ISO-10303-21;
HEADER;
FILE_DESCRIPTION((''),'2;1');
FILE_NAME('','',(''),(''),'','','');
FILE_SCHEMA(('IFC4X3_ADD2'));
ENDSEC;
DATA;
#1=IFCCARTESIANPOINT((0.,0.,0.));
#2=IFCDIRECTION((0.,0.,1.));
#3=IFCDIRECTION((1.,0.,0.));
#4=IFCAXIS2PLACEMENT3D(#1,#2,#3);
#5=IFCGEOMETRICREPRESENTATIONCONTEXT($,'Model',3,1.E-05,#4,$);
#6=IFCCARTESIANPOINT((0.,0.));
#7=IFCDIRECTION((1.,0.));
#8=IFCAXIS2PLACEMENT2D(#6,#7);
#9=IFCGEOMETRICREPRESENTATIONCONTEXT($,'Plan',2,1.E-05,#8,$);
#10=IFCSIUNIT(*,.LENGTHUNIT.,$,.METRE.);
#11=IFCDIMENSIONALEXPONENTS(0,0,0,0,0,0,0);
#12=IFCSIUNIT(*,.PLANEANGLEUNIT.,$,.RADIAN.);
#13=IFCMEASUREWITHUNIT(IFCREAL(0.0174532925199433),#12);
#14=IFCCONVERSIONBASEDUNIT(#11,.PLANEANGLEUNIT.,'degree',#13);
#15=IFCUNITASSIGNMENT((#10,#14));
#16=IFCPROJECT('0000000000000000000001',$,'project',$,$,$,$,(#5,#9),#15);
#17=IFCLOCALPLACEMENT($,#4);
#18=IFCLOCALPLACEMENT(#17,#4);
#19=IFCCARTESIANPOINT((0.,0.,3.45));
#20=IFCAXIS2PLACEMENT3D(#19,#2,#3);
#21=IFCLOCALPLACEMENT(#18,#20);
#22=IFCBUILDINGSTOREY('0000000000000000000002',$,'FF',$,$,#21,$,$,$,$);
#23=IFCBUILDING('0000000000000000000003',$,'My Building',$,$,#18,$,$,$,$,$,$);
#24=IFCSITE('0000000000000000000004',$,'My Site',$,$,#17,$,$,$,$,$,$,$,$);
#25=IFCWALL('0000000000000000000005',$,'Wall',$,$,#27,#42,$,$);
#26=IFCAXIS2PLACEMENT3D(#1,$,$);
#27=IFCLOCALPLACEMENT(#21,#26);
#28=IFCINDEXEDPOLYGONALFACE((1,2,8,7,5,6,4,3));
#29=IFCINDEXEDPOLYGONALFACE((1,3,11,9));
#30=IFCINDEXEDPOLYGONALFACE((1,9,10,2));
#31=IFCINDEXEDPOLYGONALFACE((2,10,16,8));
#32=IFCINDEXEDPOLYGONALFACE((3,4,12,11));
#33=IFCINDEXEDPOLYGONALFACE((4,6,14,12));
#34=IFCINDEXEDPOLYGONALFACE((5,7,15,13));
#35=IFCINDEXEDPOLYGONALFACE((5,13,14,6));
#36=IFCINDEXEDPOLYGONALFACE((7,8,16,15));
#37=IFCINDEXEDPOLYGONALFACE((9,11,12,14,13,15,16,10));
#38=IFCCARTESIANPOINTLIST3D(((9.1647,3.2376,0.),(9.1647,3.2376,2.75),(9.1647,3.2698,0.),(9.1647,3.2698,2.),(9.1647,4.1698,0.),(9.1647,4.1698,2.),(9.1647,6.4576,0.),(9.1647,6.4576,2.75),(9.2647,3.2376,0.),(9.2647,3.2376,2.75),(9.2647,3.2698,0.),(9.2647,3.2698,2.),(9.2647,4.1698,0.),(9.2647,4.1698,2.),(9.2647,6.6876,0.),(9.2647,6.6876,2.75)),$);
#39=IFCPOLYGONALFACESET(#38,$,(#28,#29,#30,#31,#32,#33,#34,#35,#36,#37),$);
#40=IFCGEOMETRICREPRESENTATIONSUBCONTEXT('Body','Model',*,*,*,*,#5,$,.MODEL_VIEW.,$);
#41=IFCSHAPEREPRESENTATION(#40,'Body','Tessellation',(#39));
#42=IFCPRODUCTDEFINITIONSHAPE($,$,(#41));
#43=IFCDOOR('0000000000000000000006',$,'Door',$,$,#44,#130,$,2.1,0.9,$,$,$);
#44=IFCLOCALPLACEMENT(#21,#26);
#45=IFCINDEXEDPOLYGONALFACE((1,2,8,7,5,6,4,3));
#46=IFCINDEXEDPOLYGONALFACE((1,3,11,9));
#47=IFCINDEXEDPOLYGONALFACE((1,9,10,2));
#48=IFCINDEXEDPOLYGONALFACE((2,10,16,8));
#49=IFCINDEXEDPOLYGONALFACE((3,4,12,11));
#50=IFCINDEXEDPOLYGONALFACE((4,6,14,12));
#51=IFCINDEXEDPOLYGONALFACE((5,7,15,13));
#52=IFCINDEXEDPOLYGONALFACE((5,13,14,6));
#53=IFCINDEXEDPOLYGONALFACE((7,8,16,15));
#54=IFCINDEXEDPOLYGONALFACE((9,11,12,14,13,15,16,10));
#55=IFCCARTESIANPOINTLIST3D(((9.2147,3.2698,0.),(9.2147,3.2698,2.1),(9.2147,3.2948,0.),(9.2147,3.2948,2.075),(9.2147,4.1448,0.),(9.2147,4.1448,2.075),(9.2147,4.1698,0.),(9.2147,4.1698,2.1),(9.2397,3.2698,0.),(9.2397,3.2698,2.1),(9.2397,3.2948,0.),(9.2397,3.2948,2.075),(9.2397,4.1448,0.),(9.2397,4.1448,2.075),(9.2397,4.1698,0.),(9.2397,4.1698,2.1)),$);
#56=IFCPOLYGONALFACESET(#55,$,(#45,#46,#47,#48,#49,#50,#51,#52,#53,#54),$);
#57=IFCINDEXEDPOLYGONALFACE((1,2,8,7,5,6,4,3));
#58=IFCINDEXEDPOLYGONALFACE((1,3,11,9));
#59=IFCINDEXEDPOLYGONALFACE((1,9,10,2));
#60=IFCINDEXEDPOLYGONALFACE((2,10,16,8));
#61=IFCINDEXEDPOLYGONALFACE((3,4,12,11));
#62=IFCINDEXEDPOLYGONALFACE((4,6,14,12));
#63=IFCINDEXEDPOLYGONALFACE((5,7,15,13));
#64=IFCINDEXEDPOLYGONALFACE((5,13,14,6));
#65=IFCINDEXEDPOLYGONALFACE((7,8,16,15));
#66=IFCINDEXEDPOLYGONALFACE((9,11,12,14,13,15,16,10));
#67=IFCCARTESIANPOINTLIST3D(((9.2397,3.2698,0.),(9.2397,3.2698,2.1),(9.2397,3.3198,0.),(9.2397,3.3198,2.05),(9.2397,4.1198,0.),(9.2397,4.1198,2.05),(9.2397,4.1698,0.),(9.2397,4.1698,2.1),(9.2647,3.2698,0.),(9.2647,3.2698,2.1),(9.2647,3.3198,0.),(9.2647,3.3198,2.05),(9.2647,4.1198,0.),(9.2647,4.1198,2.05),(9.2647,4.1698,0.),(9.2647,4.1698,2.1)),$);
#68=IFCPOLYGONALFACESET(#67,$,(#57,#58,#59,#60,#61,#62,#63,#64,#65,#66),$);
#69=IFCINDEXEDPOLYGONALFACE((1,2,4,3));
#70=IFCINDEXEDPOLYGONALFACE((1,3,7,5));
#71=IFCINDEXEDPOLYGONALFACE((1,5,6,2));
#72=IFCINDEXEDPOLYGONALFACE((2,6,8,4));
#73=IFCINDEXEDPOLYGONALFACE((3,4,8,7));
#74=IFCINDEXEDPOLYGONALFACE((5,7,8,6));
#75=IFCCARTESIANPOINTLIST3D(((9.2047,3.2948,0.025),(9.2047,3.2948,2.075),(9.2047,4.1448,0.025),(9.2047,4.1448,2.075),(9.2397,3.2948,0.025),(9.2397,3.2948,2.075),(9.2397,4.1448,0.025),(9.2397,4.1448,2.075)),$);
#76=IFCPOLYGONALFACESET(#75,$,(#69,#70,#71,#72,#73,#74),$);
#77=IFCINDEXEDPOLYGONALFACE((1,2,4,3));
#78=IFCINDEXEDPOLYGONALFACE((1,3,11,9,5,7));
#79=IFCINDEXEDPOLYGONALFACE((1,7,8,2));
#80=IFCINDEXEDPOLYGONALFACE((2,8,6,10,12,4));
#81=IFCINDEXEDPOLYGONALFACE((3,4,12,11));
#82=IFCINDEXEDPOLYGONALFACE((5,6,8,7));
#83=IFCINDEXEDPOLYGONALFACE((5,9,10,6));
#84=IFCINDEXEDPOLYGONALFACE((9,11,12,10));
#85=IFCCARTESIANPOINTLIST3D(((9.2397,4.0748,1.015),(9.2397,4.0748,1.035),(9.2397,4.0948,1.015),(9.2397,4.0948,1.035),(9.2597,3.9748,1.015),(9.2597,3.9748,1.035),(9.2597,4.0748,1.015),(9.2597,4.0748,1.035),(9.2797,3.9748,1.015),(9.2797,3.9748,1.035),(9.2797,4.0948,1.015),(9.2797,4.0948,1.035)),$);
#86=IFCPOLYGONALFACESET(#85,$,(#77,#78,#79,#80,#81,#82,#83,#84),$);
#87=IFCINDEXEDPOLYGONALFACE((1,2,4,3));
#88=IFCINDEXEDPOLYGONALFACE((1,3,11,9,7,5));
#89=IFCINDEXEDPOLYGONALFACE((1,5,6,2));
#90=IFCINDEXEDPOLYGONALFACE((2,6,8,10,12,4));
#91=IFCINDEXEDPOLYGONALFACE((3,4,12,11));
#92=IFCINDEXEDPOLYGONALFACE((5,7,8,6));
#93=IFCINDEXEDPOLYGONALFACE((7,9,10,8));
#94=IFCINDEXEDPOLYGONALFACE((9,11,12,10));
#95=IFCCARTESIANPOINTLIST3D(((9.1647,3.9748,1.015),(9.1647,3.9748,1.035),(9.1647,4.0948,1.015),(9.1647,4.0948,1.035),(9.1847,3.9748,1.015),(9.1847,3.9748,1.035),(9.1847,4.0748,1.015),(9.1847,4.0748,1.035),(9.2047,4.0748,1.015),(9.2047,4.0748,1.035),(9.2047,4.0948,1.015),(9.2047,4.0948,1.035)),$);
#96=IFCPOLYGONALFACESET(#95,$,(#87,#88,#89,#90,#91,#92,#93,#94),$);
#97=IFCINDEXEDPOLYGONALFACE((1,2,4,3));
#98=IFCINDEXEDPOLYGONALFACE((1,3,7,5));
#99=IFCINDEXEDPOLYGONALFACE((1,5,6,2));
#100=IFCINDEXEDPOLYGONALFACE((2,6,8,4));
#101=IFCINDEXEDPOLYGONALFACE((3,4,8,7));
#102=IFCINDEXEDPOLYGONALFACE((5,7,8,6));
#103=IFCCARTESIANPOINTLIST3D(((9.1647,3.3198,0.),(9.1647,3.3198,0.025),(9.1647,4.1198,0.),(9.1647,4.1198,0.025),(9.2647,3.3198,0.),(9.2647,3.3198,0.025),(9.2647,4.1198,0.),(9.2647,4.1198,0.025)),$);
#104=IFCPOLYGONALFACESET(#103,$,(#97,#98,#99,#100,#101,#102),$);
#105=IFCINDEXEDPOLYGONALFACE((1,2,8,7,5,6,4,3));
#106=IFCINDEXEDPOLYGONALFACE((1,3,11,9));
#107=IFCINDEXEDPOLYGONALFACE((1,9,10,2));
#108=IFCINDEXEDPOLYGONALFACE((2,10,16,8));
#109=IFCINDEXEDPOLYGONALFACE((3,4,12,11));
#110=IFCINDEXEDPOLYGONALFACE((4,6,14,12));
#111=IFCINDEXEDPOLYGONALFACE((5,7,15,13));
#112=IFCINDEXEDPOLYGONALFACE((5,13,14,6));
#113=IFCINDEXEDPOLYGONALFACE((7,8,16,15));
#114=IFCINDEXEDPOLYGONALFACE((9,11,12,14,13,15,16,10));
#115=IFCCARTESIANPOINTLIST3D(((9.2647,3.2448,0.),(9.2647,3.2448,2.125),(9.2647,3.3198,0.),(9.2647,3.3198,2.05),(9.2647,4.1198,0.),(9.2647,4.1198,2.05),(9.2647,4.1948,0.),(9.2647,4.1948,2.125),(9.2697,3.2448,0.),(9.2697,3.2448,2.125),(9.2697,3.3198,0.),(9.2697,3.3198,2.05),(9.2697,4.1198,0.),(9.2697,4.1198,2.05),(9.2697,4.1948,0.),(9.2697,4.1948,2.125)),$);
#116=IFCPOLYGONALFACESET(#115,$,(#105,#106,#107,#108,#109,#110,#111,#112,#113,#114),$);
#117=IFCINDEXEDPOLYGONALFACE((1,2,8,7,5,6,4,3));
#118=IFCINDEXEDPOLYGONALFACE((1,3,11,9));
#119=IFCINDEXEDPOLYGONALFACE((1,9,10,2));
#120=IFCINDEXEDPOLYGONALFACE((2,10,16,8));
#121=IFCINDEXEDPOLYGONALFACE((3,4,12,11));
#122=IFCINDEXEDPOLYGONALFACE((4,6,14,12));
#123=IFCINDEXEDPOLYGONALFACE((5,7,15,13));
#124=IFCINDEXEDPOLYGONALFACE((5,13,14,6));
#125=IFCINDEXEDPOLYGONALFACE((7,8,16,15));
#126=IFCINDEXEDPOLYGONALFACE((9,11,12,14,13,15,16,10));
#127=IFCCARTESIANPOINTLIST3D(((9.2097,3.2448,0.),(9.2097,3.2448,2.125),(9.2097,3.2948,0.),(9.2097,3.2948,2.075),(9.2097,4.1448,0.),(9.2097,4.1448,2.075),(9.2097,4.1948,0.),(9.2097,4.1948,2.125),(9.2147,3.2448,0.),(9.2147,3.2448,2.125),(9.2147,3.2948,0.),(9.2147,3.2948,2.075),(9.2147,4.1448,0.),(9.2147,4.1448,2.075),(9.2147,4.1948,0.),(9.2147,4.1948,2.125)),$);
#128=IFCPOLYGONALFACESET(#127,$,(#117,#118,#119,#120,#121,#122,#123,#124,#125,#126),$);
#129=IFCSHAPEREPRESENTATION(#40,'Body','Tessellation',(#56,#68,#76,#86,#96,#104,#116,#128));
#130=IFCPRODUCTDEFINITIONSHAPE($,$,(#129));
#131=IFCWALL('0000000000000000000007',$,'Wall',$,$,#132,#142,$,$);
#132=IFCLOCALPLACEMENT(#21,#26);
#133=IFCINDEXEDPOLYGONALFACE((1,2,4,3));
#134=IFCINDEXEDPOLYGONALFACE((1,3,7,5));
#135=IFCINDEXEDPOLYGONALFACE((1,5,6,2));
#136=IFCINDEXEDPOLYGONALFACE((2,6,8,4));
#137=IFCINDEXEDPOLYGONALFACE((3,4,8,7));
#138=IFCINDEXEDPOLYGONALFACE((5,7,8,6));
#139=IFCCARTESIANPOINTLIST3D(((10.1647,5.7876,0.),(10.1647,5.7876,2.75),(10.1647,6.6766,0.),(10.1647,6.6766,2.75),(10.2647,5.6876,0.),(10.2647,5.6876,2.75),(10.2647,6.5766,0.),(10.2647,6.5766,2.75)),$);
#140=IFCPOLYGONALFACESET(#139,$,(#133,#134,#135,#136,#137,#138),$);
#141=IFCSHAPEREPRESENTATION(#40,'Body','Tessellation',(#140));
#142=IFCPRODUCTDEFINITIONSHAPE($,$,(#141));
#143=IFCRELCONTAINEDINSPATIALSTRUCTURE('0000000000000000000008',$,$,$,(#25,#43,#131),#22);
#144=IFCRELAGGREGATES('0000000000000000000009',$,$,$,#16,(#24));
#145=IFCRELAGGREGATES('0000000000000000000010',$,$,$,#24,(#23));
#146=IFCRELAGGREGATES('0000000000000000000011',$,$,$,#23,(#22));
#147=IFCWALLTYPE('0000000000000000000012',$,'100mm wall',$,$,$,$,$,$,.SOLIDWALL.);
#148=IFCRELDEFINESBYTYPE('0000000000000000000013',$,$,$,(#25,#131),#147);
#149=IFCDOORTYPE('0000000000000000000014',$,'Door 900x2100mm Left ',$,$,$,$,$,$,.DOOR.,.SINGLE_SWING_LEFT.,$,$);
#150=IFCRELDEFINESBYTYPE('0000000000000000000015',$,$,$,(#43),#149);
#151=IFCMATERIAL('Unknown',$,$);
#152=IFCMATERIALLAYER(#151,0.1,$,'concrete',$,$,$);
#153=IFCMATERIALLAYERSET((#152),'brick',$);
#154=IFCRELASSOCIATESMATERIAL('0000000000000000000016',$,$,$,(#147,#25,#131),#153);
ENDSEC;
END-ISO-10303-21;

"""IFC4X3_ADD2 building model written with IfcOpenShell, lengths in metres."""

from ifc_helpers import new_model, entity, si_unit, converted_unit, frame, origin_with_axes, origin_2d_with_axis, place, context, subcontext, project, spatial, line, indexed_curve, outline, extrude, shape, source, transform, mapped, material, layer, layer_set, layer_usage, type_object, type_shapes, element, fill, save


model = new_model("IFC4X3_ADD2")

# Units and contexts
model_context = context("Model", 3, precision=1e-05, world=origin_with_axes())
plan_context = context("Plan", 2, precision=1e-05, world=origin_2d_with_axis())
body_context_1 = subcontext(model_context, "Body", "Model", "MODEL_VIEW")
body_context_2 = subcontext(plan_context, "Body", "Plan", "PLAN_VIEW")
ifc_project = project(units=[si_unit("LENGTHUNIT", "METRE"), converted_unit("PLANEANGLEUNIT", "degree", entity("IfcReal", 0.0174532925199433), si_unit("PLANEANGLEUNIT", "RADIAN"), dimensions=[0, 0, 0, 0, 0, 0, 0])], contexts=[model_context, plan_context])

# Site, building, storey
site_placement = place(None, origin_with_axes())
site = spatial("IfcSite", under=ifc_project, at=site_placement, Name="My Site")
building_placement = place(site_placement, origin_with_axes())
building = spatial("IfcBuilding", under=site, at=building_placement, Name="My Building")
storey_placement = place(building_placement, frame((0.0, 0.0, 3.45), z_axis=(0.0, 0.0, 1.0), x_axis=(1.0, 0.0, 0.0)))
storey = spatial("IfcBuildingStorey", under=building, at=storey_placement, Name="FF")

# Shared definitions
ifc_material = material(Name="Unknown")

# Wall, opening, door
ifc_layer_1 = layer(ifc_material, 0.1, Name="concrete")
ifc_layer_set_1 = layer_set([ifc_layer_1], Name="brick")
wall_type_1 = type_object("IfcWallType", Name="100mm wall", PredefinedType="SOLIDWALL", material=ifc_layer_set_1)
shared_shape_1 = source(origin_with_axes(), body_context_1, "Body", "SweptSolid", [
    extrude(outline(indexed_curve([(0.0, 0.0), (0.9, 0.0), (0.9, 2.1), (0.0, 2.1)], segments=[line(1, 2, 3, 4, 1)])), frame((0.0, -0.6, 0.0), z_axis=(0.0, -1.0, 0.0), x_axis=(1.0, 0.0, 0.0)), (0.0, 0.0, -1.0), 1.2),
])
door_type_1 = type_object("IfcDoorType", Name="Door 900x2100mm Left ", OperationType="SINGLE_SWING_LEFT", PredefinedType="DOOR")
shared_shape_2 = source(origin_with_axes(), body_context_1, "Body", "SweptSolid", [
    extrude(outline(indexed_curve([(0.0, 0.0), (0.0, 2.1), (0.9, 2.1), (0.9, 0.0), (0.875, 0.0), (0.875, 2.075), (0.025, 2.075), (0.025, 0.0)], segments=[line(1, 2, 3, 4, 5, 6, 7, 8, 1)])), frame((0.0, 0.025, 0.0), z_axis=(0.0, -1.0, 0.0), x_axis=(1.0, 0.0, 0.0)), (0.0, 0.0, -1.0), 0.025),
    extrude(outline(indexed_curve([(0.0, 0.0), (0.0, 2.1), (0.9, 2.1), (0.9, 0.0), (0.85, 0.0), (0.85, 2.05), (0.05, 2.05), (0.05, 0.0)], segments=[line(1, 2, 3, 4, 5, 6, 7, 8, 1)])), frame((0.0, 0.0, 0.0), z_axis=(0.0, -1.0, 0.0), x_axis=(1.0, 0.0, 0.0)), (0.0, 0.0, -1.0), 0.025),
    extrude(outline(indexed_curve([(0.0, 0.0), (0.85, 0.0), (0.85, 0.035), (0.0, 0.035)], segments=[line(1, 2, 3, 4, 1)])), frame((0.025, 0.025, 0.025), z_axis=(0.0, 0.0, 1.0), x_axis=(1.0, 0.0, 0.0)), (0.0, 0.0, 1.0), 2.05),
    extrude(outline(indexed_curve([(0.0, 0.0), (0.0, -0.04), (-0.12, -0.04), (-0.12, -0.02), (-0.02, -0.02), (-0.02, 0.0)], segments=[line(1, 2, 3, 4, 5, 6, 1)])), frame((0.825, 0.025, 1.015), z_axis=(0.0, 0.0, 1.0), x_axis=(1.0, 0.0, 0.0)), (0.0, 0.0, 1.0), 0.02),
    extrude(outline(indexed_curve([(0.0, 0.0), (0.0, 0.04), (-0.12, 0.04), (-0.12, 0.02), (-0.02, 0.02), (-0.02, 0.0)], segments=[line(1, 2, 3, 4, 5, 6, 1)])), frame((0.825, 0.06, 1.015), z_axis=(0.0, 0.0, 1.0), x_axis=(1.0, 0.0, 0.0)), (0.0, 0.0, 1.0), 0.02),
    extrude(outline(indexed_curve([(0.0, 0.0), (0.8, 0.0), (0.8, 0.1), (0.0, 0.1)], segments=[line(1, 2, 3, 4, 1)])), frame((0.05, 0.0, 0.0), z_axis=(0.0, 0.0, 1.0), x_axis=(1.0, 0.0, 0.0)), (0.0, 0.0, 1.0), 0.025),
    extrude(outline(indexed_curve([(0.0, 0.0), (0.0, 2.125), (0.95, 2.125), (0.95, 0.0), (0.875, 0.0), (0.875, 2.05), (0.075, 2.05), (0.075, 0.0)], segments=[line(1, 2, 3, 4, 5, 6, 7, 8, 1)])), frame((-0.025, -0.005, 0.0), z_axis=(0.0, -1.0, 0.0), x_axis=(1.0, 0.0, 0.0)), (0.0, 0.0, -1.0), 0.005),
    extrude(outline(indexed_curve([(0.0, 0.0), (0.0, 2.125), (0.95, 2.125), (0.95, 0.0), (0.9, 0.0), (0.9, 2.075), (0.05, 2.075), (0.05, 0.0)], segments=[line(1, 2, 3, 4, 5, 6, 7, 8, 1)])), frame((-0.025, 0.05, 0.0), z_axis=(0.0, -1.0, 0.0), x_axis=(1.0, 0.0, 0.0)), (0.0, 0.0, -1.0), 0.005),
])
shared_shape_3 = source(origin_with_axes(), body_context_2, "Body", "Curve2D", [
    entity("IfcIndexedPolyCurve", entity("IfcCartesianPointList2D", [[0.0, 0.0], [0.0, 0.05], [0.025, 0.05], [0.025, 0.025], [0.05, 0.025], [0.05, 0.0]]), [entity("IfcLineIndex", [1, 2, 3, 4, 5, 6, 1])]),
    entity("IfcIndexedPolyCurve", entity("IfcCartesianPointList2D", [[0.9, 0.0], [0.9, 0.05], [0.875, 0.05], [0.875, 0.025], [0.85, 0.025], [0.85, 0.0]]), [entity("IfcLineIndex", [1, 2, 3, 4, 5, 6, 1])]),
    entity("IfcTrimmedCurve", entity("IfcEllipse", entity("IfcAxis2Placement2D", entity("IfcCartesianPoint", [0.06, 0.05]), entity("IfcDirection", [1.0, 0.0])), 0.815, 0.85), [entity("IfcCartesianPoint", [0.875, 0.05])], [entity("IfcCartesianPoint", [0.06, 0.9])], True, "CARTESIAN"),
    entity("IfcIndexedPolyCurve", entity("IfcCartesianPointList2D", [[0.025, 0.05], [0.06, 0.05], [0.06, 0.9], [0.025, 0.9]]), [entity("IfcLineIndex", [1, 2, 3, 4, 1])]),
])
type_shapes(door_type_1, [shared_shape_2, shared_shape_3])
ifc_layer_usage_1 = layer_usage(ifc_layer_set_1, "AXIS2", "POSITIVE", 0.0)
wall_1_placement = place(storey_placement, frame((9.2647, 3.2376, 0.0), z_axis=(0.0, 0.0, 1.0), x_axis=(0.0, 1.0, 0.0)))
wall_1 = element("IfcWall", 1, at=wall_1_placement, inside=storey, type_object=wall_type_1, material=ifc_layer_usage_1, Name="Wall", context=body_context_1, shape_type="SweptSolid", body=[
    extrude(outline(indexed_curve([(0.0, 0.0), (0.0, 0.1), (3.22, 0.1), (3.45, 0.0)], segments=[line(1, 2, 3, 4, 1)])), origin_with_axes(), (0.0, 0.0, 1.0), 2.75),
])
opening_1_placement = place(wall_1_placement, frame((0.0322, 0.0, -0.1), z_axis=(0.0, 0.0, 1.0), x_axis=(1.0, 0.0, 0.0)))
opening_1 = element("IfcOpeningElement", 2, at=opening_1_placement, cuts=wall_1, PredefinedType="OPENING", context=body_context_1, shape_type="MappedRepresentation", body=[
    mapped(shared_shape_1, transform((0.0, 0.0, 0.0), x_axis=(1.0, 0.0, 0.0), y_axis=(0.0, 1.0, 0.0), z_axis=(0.0, 0.0, 1.0), scale=1.0)),
])
door_1_placement = place(opening_1_placement, frame((0.0, 0.0, 0.1), z_axis=(0.0, 0.0, 1.0), x_axis=(1.0, 0.0, 0.0)))
door_1 = element("IfcDoor", 3, at=door_1_placement, inside=storey, type_object=door_type_1, Name="Door", OverallHeight=2.1, OverallWidth=0.9, shapes=[
    shape(body_context_1, "Body", "MappedRepresentation", [mapped(shared_shape_2, transform((0.0, 0.0, 0.0), x_axis=(1.0, 0.0, 0.0), y_axis=(0.0, 1.0, 0.0), z_axis=(0.0, 0.0, 1.0), scale=1.0))]),
    shape(body_context_2, "Body", "MappedRepresentation", [mapped(shared_shape_3, transform((0.0, 0.0, 0.0), x_axis=(1.0, 0.0, 0.0), y_axis=(0.0, 1.0, 0.0), z_axis=(0.0, 0.0, 1.0), scale=1.0))]),
])
fill(opening_1, door_1)

# Wall
ifc_layer_usage_2 = layer_usage(ifc_layer_set_1, "AXIS2", "POSITIVE", 0.0)
wall_2_placement = place(storey_placement, frame((10.2647, 5.7876, 0.0), z_axis=(0.0, 0.0, 1.0), x_axis=(0.0, 1.0, 0.0)))
element("IfcWall", 4, at=wall_2_placement, inside=storey, type_object=wall_type_1, material=ifc_layer_usage_2, Name="Wall", context=body_context_1, shape_type="SweptSolid", body=[
    extrude(outline(indexed_curve([(-0.1, 0.0), (0.0, 0.1), (0.889, 0.1), (0.789, 0.0)], segments=[line(1, 2, 3, 4, 1)])), origin_with_axes(), (0.0, 0.0, 1.0), 2.75),
])

save(model, "model.ifc")
